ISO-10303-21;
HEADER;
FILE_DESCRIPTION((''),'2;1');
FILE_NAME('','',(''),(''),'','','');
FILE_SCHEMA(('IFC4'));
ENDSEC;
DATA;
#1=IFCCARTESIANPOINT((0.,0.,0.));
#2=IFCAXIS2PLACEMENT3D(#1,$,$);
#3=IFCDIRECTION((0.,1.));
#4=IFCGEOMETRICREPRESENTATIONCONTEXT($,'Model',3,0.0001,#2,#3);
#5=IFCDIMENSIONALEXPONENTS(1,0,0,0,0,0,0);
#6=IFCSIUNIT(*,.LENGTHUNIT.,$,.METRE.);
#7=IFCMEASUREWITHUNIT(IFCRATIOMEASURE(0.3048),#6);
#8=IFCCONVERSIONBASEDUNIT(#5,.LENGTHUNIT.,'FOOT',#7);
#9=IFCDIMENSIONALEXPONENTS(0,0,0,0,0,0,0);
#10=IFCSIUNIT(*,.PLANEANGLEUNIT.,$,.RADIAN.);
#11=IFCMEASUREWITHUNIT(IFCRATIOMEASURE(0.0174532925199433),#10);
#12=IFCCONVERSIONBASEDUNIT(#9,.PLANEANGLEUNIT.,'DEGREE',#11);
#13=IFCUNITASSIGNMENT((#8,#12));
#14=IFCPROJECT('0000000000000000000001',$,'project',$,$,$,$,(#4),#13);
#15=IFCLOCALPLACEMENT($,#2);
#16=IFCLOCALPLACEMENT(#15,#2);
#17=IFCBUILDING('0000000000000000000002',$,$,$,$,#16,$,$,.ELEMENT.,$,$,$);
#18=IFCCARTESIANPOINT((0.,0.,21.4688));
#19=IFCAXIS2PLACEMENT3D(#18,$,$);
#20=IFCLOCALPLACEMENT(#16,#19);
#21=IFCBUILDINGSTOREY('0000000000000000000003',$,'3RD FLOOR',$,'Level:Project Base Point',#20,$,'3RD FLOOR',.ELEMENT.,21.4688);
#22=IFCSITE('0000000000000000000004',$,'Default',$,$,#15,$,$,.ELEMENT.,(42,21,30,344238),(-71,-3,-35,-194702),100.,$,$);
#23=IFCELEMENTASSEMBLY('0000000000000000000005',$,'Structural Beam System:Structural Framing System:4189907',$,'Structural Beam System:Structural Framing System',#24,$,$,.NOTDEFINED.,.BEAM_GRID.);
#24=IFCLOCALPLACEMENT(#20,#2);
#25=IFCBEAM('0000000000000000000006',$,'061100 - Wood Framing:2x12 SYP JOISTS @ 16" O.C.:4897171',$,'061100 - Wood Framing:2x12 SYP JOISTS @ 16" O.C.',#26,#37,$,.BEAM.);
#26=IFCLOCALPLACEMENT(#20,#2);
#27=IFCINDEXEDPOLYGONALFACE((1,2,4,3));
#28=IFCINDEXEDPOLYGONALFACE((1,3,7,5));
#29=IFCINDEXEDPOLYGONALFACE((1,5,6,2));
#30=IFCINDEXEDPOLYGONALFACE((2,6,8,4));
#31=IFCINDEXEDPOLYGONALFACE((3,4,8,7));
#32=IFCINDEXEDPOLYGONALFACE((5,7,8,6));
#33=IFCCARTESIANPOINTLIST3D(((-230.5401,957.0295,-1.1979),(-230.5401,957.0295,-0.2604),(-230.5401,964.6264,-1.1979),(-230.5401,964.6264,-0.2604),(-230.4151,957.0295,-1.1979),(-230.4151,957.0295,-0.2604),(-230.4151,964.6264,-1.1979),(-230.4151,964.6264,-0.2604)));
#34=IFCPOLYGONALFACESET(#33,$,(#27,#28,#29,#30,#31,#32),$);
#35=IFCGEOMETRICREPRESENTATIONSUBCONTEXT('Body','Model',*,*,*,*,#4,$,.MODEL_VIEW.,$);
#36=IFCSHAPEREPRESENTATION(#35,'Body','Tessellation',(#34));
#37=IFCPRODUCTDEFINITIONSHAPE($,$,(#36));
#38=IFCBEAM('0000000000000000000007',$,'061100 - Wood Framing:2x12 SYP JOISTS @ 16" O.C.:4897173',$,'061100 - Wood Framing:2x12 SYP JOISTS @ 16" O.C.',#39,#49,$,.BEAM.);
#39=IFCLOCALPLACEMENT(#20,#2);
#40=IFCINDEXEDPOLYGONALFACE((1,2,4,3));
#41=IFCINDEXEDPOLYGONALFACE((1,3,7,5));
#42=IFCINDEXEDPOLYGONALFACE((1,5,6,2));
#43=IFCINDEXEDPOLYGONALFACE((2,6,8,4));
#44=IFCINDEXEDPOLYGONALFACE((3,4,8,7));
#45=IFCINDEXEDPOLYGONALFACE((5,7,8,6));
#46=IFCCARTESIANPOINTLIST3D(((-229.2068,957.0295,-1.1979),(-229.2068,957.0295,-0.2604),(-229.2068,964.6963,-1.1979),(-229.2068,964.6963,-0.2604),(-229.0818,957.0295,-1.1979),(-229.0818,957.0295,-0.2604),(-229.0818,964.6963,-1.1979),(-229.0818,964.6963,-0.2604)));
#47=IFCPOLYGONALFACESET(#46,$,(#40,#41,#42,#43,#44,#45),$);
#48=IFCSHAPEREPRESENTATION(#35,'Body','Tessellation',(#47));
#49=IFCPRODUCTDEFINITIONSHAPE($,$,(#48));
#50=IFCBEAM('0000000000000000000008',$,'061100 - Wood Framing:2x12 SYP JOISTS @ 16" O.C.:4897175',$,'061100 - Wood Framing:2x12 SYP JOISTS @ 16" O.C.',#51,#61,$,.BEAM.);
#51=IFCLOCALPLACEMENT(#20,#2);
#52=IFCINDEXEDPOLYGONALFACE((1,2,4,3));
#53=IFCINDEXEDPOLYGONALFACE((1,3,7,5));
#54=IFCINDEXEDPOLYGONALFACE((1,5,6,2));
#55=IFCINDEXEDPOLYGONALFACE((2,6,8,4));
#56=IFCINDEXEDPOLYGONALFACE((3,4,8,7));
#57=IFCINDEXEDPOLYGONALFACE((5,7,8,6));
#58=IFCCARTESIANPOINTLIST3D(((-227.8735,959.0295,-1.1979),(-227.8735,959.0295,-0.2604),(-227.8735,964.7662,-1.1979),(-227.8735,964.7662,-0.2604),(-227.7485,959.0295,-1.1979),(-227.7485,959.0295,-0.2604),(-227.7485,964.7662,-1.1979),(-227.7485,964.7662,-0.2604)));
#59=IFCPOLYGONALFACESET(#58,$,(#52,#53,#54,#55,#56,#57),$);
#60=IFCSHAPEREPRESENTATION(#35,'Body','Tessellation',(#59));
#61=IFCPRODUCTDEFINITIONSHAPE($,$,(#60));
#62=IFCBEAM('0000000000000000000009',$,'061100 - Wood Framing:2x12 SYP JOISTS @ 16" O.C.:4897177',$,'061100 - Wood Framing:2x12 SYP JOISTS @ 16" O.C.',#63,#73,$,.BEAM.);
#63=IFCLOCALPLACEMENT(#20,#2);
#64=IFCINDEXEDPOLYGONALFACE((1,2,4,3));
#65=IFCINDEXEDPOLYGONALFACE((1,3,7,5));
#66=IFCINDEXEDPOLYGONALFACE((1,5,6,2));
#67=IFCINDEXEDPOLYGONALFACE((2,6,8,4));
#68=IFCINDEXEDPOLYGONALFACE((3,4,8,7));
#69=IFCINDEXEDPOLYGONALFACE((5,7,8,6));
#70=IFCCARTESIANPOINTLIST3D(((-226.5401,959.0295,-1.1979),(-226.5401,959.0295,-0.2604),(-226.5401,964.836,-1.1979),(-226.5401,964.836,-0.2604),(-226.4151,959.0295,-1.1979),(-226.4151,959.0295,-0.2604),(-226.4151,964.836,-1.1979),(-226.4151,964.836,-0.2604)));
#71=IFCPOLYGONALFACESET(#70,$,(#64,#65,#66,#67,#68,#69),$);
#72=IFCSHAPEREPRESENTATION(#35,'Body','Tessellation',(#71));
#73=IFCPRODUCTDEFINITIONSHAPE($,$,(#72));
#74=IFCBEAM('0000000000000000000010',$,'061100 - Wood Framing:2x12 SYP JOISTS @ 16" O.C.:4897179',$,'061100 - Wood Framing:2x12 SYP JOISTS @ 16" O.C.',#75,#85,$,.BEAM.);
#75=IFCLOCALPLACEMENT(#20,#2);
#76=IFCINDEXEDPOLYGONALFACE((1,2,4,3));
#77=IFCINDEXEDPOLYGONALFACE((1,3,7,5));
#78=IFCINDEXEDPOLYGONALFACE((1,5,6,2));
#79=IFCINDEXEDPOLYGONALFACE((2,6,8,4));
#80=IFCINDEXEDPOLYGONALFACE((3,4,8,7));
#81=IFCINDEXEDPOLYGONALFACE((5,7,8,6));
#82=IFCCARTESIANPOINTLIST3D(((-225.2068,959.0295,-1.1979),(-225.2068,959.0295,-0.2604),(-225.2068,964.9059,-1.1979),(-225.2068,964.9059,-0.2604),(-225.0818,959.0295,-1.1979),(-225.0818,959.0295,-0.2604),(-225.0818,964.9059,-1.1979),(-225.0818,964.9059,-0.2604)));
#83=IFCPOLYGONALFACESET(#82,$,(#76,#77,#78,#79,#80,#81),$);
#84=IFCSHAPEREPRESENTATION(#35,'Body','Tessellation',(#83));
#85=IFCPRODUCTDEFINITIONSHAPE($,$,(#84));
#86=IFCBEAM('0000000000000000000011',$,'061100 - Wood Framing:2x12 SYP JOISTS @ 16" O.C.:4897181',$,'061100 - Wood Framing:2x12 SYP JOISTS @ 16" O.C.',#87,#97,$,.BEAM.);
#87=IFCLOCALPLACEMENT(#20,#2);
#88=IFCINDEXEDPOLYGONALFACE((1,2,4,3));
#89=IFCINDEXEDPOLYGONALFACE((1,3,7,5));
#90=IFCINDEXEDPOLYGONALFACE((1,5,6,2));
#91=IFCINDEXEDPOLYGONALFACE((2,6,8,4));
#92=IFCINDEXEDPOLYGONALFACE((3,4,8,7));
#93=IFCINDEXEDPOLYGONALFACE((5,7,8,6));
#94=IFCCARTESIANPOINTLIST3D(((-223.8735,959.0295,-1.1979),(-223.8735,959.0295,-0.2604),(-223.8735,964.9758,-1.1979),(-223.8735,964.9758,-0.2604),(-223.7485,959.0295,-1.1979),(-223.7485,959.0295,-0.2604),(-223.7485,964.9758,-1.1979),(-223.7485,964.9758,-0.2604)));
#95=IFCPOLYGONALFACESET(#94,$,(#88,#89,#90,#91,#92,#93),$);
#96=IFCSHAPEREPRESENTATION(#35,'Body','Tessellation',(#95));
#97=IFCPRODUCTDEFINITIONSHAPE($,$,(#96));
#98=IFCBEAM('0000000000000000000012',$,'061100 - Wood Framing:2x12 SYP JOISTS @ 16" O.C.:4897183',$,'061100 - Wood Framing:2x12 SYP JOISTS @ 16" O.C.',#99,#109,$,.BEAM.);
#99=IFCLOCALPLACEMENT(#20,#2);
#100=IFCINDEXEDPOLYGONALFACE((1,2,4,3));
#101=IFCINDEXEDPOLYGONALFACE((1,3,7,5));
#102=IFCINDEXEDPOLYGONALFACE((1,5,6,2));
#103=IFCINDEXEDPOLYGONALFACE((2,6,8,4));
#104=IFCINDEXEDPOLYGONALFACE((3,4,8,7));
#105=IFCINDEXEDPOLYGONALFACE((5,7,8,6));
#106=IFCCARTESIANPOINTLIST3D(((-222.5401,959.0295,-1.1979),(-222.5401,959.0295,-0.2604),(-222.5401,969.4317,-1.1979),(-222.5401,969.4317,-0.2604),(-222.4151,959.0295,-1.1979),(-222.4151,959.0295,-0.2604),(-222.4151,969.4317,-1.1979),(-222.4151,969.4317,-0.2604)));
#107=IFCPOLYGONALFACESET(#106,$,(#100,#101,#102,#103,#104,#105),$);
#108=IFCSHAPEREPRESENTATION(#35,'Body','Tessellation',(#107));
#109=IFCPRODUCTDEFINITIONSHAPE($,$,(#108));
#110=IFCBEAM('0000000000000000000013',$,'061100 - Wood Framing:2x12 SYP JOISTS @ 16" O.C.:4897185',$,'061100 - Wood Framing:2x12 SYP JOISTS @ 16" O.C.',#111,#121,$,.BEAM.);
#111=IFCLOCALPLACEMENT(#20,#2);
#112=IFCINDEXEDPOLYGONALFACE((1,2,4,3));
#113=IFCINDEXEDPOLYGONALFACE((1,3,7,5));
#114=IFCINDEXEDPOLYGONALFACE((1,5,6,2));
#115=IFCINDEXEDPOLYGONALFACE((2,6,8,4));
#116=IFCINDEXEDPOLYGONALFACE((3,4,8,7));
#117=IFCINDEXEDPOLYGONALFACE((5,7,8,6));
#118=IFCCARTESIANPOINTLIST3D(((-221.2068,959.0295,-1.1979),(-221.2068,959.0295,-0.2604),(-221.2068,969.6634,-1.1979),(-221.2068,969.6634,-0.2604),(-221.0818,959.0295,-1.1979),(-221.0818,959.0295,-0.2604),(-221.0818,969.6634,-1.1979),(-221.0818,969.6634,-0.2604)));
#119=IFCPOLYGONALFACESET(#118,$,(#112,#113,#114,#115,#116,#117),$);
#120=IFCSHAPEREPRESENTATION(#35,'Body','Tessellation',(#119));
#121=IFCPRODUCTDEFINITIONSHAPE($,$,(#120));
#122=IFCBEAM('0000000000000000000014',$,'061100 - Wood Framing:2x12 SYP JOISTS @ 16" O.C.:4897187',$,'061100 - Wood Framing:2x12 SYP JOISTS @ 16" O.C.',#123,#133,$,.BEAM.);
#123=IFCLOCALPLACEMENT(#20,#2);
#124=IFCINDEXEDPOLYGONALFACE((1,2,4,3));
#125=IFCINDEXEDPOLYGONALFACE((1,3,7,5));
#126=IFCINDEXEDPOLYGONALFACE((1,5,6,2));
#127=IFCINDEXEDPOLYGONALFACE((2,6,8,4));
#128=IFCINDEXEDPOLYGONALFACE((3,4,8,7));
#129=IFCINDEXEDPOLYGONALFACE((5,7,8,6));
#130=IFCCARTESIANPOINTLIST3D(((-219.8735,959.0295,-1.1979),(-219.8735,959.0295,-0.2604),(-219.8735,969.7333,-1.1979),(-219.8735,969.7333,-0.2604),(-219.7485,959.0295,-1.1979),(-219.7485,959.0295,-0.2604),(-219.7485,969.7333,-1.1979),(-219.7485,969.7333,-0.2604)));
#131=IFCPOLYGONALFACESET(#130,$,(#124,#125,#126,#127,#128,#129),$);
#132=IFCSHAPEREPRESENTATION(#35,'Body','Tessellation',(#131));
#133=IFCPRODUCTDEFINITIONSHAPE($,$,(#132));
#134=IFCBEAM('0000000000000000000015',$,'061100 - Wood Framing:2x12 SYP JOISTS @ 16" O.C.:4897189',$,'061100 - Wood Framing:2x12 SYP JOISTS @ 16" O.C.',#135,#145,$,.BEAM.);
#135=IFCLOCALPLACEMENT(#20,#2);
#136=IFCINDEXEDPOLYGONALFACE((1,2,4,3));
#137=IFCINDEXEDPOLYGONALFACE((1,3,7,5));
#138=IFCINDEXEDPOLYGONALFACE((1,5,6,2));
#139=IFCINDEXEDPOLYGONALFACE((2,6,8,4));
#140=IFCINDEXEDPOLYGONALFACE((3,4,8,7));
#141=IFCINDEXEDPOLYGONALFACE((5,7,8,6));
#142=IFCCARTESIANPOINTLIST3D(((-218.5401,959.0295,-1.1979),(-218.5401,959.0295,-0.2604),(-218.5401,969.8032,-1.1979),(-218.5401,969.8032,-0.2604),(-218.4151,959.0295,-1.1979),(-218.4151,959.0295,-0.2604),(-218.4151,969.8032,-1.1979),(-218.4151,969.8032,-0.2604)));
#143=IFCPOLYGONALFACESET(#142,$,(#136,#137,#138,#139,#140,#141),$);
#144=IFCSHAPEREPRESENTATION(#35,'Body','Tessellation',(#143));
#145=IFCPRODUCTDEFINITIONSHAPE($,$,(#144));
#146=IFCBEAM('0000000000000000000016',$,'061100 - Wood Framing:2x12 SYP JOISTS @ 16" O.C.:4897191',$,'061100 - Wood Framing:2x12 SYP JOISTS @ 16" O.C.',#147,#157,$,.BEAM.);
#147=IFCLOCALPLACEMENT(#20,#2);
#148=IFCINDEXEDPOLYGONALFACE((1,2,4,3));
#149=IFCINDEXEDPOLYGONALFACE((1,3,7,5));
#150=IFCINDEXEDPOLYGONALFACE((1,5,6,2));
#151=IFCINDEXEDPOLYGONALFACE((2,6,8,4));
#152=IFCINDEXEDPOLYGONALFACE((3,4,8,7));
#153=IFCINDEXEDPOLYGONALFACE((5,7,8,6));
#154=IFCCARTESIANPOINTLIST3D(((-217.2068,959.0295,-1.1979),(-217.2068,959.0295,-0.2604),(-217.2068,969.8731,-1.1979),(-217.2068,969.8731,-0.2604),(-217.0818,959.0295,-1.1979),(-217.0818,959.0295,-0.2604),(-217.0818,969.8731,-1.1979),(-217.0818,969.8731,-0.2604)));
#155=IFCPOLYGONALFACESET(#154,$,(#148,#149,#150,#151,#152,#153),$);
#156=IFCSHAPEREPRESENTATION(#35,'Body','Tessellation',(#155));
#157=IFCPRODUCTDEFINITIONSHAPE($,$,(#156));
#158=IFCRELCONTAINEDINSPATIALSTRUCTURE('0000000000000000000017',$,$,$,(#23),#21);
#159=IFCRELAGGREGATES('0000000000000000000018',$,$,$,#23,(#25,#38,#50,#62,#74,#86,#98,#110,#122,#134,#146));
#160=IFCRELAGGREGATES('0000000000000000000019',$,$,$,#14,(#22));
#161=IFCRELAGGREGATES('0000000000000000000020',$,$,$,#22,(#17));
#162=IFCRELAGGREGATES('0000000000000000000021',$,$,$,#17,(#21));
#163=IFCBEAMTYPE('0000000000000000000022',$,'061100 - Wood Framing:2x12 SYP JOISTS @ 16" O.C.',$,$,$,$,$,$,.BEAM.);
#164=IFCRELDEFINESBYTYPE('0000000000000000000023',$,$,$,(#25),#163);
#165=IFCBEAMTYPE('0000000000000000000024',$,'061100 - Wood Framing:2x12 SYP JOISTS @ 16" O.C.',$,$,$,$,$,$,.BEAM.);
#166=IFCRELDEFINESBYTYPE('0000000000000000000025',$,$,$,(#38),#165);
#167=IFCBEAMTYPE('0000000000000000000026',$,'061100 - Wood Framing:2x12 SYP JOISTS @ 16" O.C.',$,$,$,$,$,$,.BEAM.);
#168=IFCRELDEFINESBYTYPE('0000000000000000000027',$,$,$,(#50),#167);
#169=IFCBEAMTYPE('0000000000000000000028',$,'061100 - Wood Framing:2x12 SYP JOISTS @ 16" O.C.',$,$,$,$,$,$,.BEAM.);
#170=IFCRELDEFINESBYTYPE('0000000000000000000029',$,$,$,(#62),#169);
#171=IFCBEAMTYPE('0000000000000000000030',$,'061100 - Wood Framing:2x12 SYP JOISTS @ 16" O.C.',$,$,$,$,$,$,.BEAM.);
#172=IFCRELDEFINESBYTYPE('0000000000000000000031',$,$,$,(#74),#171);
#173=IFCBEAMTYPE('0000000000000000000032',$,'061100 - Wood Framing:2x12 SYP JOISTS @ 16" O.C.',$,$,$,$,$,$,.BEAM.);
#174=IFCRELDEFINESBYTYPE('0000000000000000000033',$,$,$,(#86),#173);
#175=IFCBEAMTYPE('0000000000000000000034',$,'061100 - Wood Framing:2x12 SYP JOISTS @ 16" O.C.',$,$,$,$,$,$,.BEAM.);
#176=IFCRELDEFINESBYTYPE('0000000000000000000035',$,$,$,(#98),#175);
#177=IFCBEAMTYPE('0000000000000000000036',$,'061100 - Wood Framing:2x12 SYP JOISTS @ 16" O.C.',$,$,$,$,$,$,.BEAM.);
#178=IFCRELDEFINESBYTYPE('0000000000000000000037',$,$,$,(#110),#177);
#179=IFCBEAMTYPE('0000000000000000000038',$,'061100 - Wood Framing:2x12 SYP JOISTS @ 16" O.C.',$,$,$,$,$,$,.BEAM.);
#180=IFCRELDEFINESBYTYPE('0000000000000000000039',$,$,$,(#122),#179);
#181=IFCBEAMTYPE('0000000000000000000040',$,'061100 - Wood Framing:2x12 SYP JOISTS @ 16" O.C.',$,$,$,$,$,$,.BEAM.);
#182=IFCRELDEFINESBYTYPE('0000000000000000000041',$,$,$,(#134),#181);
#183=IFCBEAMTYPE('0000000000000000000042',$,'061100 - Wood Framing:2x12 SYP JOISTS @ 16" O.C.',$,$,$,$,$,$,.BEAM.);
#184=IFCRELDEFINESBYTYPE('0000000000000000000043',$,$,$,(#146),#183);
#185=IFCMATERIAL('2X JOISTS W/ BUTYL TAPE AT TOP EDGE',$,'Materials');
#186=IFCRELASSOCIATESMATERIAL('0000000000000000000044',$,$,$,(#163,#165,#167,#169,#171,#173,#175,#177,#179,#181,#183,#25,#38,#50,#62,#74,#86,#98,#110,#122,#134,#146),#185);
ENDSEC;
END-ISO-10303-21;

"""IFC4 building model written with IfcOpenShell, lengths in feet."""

from ifc_helpers import new_model, entity, si_unit, converted_unit, direction, frame, origin, origin_2d_with_axis, place, context, subcontext, project, spatial, rectangle, extrude, source, transform, mapped, material, material_profile, profile_set, profile_usage, type_object, type_shapes, element, aggregate, save


model = new_model("IFC4")

# Units and contexts
model_context = context("Model", 3, precision=0.0001, world=origin(), true_north=direction((0.0, 1.0)))
body_context = subcontext(model_context, "Body", "Model", "MODEL_VIEW")
ifc_project = project(units=[converted_unit("LENGTHUNIT", "FOOT", entity("IfcRatioMeasure", 0.3048), si_unit("LENGTHUNIT", "METRE"), dimensions=[1, 0, 0, 0, 0, 0, 0]), converted_unit("PLANEANGLEUNIT", "DEGREE", entity("IfcRatioMeasure", 0.0174532925199433), si_unit("PLANEANGLEUNIT", "RADIAN"), dimensions=[0, 0, 0, 0, 0, 0, 0])], contexts=[model_context])

# Site, building, storey
site_placement = place(None, origin())
site = spatial("IfcSite", under=ifc_project, at=site_placement, Name="Default", CompositionType="ELEMENT", RefLatitude=(42, 21, 30, 344238), RefLongitude=(-71, -3, -35, -194702), RefElevation=100.0)
building_placement = place(site_placement, origin())
building = spatial("IfcBuilding", under=site, at=building_placement, CompositionType="ELEMENT")
storey_placement = place(building_placement, frame((0.0, 0.0, 21.4688)))
storey = spatial("IfcBuildingStorey", under=building, at=storey_placement, Name="3RD FLOOR", ObjectType="Level:Project Base Point", LongName="3RD FLOOR", CompositionType="ELEMENT", Elevation=21.4688)

# Element assembly, beams
assembly_1_placement = place(storey_placement, origin())
assembly_1 = element("IfcElementAssembly", 1, at=assembly_1_placement, inside=storey, Name="Structural Beam System:Structural Framing System:4189907", ObjectType="Structural Beam System:Structural Framing System", AssemblyPlace="NOTDEFINED", PredefinedType="BEAM_GRID")
ifc_material_1 = material(Name="2X JOISTS W/ BUTYL TAPE AT TOP EDGE", Category="Materials")
ifc_material_profile_1 = material_profile(ifc_material_1, rectangle(XDim=0.9375, YDim=0.125, at=origin_2d_with_axis()), Name="2x12 SYP JOISTS @ 16\" O.C.")
ifc_profile_set_1 = profile_set([ifc_material_profile_1], Name="2x12 SYP JOISTS @ 16\" O.C.")
ifc_profile_usage_1 = profile_usage(ifc_profile_set_1, cardinal=8)
beam_type_1 = type_object("IfcBeamType", Name="061100 - Wood Framing:2x12 SYP JOISTS @ 16\" O.C.", PredefinedType="BEAM", material=ifc_profile_set_1)
shared_shape_1 = source(origin(), body_context, "Body", "SweptSolid", [
    extrude(rectangle(XDim=0.9375, YDim=0.125, at=origin_2d_with_axis()), frame((-3.7984, 0.0, 0.0), z_axis=(1.0, 0.0, 0.0), x_axis=(0.0, 0.0, -1.0)), (0.0, 0.0, 1.0), 7.5969),
])
type_shapes(beam_type_1, [shared_shape_1])
beam_1_placement = place(assembly_1_placement, frame((-230.4776, 960.828, -0.7292), z_axis=(0.0, 0.0, 1.0), x_axis=(0.0, 1.0, 0.0)))
beam_1 = element("IfcBeam", 2, at=beam_1_placement, type_object=beam_type_1, material=ifc_profile_usage_1, Name="061100 - Wood Framing:2x12 SYP JOISTS @ 16\" O.C.:4897171", ObjectType="061100 - Wood Framing:2x12 SYP JOISTS @ 16\" O.C.", PredefinedType="BEAM", context=body_context, shape_type="MappedRepresentation", body=[
    mapped(shared_shape_1, transform((0.0, 0.0, 0.0), scale=1.0)),
])
ifc_profile_usage_2 = profile_usage(ifc_profile_set_1, cardinal=8)
beam_type_2 = type_object("IfcBeamType", Name="061100 - Wood Framing:2x12 SYP JOISTS @ 16\" O.C.", PredefinedType="BEAM", material=ifc_profile_set_1)
shared_shape_2 = source(origin(), body_context, "Body", "SweptSolid", [
    extrude(rectangle(XDim=0.9375, YDim=0.125, at=origin_2d_with_axis()), frame((-3.8334, 0.0, 0.0), z_axis=(1.0, 0.0, 0.0), x_axis=(0.0, 0.0, -1.0)), (0.0, 0.0, 1.0), 7.6668),
])
type_shapes(beam_type_2, [shared_shape_2])
beam_2_placement = place(assembly_1_placement, frame((-229.1443, 960.8629, -0.7292), z_axis=(0.0, 0.0, 1.0), x_axis=(0.0, 1.0, 0.0)))
beam_2 = element("IfcBeam", 3, at=beam_2_placement, type_object=beam_type_2, material=ifc_profile_usage_2, Name="061100 - Wood Framing:2x12 SYP JOISTS @ 16\" O.C.:4897173", ObjectType="061100 - Wood Framing:2x12 SYP JOISTS @ 16\" O.C.", PredefinedType="BEAM", context=body_context, shape_type="MappedRepresentation", body=[
    mapped(shared_shape_2, transform((0.0, 0.0, 0.0), scale=1.0)),
])
ifc_profile_usage_3 = profile_usage(ifc_profile_set_1, cardinal=8)
beam_type_3 = type_object("IfcBeamType", Name="061100 - Wood Framing:2x12 SYP JOISTS @ 16\" O.C.", PredefinedType="BEAM", material=ifc_profile_set_1)
shared_shape_3 = source(origin(), body_context, "Body", "SweptSolid", [
    extrude(rectangle(XDim=0.9375, YDim=0.125, at=origin_2d_with_axis()), frame((-2.8683, 0.0, 0.0), z_axis=(1.0, 0.0, 0.0), x_axis=(0.0, 0.0, -1.0)), (0.0, 0.0, 1.0), 5.7366),
])
type_shapes(beam_type_3, [shared_shape_3])
beam_3_placement = place(assembly_1_placement, frame((-227.811, 961.8978, -0.7292), z_axis=(0.0, 0.0, 1.0), x_axis=(0.0, 1.0, 0.0)))
beam_3 = element("IfcBeam", 4, at=beam_3_placement, type_object=beam_type_3, material=ifc_profile_usage_3, Name="061100 - Wood Framing:2x12 SYP JOISTS @ 16\" O.C.:4897175", ObjectType="061100 - Wood Framing:2x12 SYP JOISTS @ 16\" O.C.", PredefinedType="BEAM", context=body_context, shape_type="MappedRepresentation", body=[
    mapped(shared_shape_3, transform((0.0, 0.0, 0.0), scale=1.0)),
])
ifc_profile_usage_4 = profile_usage(ifc_profile_set_1, cardinal=8)
beam_type_4 = type_object("IfcBeamType", Name="061100 - Wood Framing:2x12 SYP JOISTS @ 16\" O.C.", PredefinedType="BEAM", material=ifc_profile_set_1)
shared_shape_4 = source(origin(), body_context, "Body", "SweptSolid", [
    extrude(rectangle(XDim=0.9375, YDim=0.125, at=origin_2d_with_axis()), frame((-2.9033, 0.0, 0.0), z_axis=(1.0, 0.0, 0.0), x_axis=(0.0, 0.0, -1.0)), (0.0, 0.0, 1.0), 5.8065),
])
type_shapes(beam_type_4, [shared_shape_4])
beam_4_placement = place(assembly_1_placement, frame((-226.4776, 961.9328, -0.7292), z_axis=(0.0, 0.0, 1.0), x_axis=(0.0, 1.0, 0.0)))
beam_4 = element("IfcBeam", 5, at=beam_4_placement, type_object=beam_type_4, material=ifc_profile_usage_4, Name="061100 - Wood Framing:2x12 SYP JOISTS @ 16\" O.C.:4897177", ObjectType="061100 - Wood Framing:2x12 SYP JOISTS @ 16\" O.C.", PredefinedType="BEAM", context=body_context, shape_type="MappedRepresentation", body=[
    mapped(shared_shape_4, transform((0.0, 0.0, 0.0), scale=1.0)),
])
ifc_profile_usage_5 = profile_usage(ifc_profile_set_1, cardinal=8)
beam_type_5 = type_object("IfcBeamType", Name="061100 - Wood Framing:2x12 SYP JOISTS @ 16\" O.C.", PredefinedType="BEAM", material=ifc_profile_set_1)
shared_shape_5 = source(origin(), body_context, "Body", "SweptSolid", [
    extrude(rectangle(XDim=0.9375, YDim=0.125, at=origin_2d_with_axis()), frame((-2.9382, 0.0, 0.0), z_axis=(1.0, 0.0, 0.0), x_axis=(0.0, 0.0, -1.0)), (0.0, 0.0, 1.0), 5.8764),
])
type_shapes(beam_type_5, [shared_shape_5])
beam_5_placement = place(assembly_1_placement, frame((-225.1443, 961.9677, -0.7292), z_axis=(0.0, 0.0, 1.0), x_axis=(0.0, 1.0, 0.0)))
beam_5 = element("IfcBeam", 6, at=beam_5_placement, type_object=beam_type_5, material=ifc_profile_usage_5, Name="061100 - Wood Framing:2x12 SYP JOISTS @ 16\" O.C.:4897179", ObjectType="061100 - Wood Framing:2x12 SYP JOISTS @ 16\" O.C.", PredefinedType="BEAM", context=body_context, shape_type="MappedRepresentation", body=[
    mapped(shared_shape_5, transform((0.0, 0.0, 0.0), scale=1.0)),
])
ifc_profile_usage_6 = profile_usage(ifc_profile_set_1, cardinal=8)
beam_type_6 = type_object("IfcBeamType", Name="061100 - Wood Framing:2x12 SYP JOISTS @ 16\" O.C.", PredefinedType="BEAM", material=ifc_profile_set_1)
shared_shape_6 = source(origin(), body_context, "Body", "SweptSolid", [
    extrude(rectangle(XDim=0.9375, YDim=0.125, at=origin_2d_with_axis()), frame((-2.9731, 0.0, 0.0), z_axis=(1.0, 0.0, 0.0), x_axis=(0.0, 0.0, -1.0)), (0.0, 0.0, 1.0), 5.9463),
])
type_shapes(beam_type_6, [shared_shape_6])
beam_6_placement = place(assembly_1_placement, frame((-223.811, 962.0027, -0.7292), z_axis=(0.0, 0.0, 1.0), x_axis=(0.0, 1.0, 0.0)))
beam_6 = element("IfcBeam", 7, at=beam_6_placement, type_object=beam_type_6, material=ifc_profile_usage_6, Name="061100 - Wood Framing:2x12 SYP JOISTS @ 16\" O.C.:4897181", ObjectType="061100 - Wood Framing:2x12 SYP JOISTS @ 16\" O.C.", PredefinedType="BEAM", context=body_context, shape_type="MappedRepresentation", body=[
    mapped(shared_shape_6, transform((0.0, 0.0, 0.0), scale=1.0)),
])
ifc_profile_usage_7 = profile_usage(ifc_profile_set_1, cardinal=8)
beam_type_7 = type_object("IfcBeamType", Name="061100 - Wood Framing:2x12 SYP JOISTS @ 16\" O.C.", PredefinedType="BEAM", material=ifc_profile_set_1)
shared_shape_7 = source(origin(), body_context, "Body", "SweptSolid", [
    extrude(rectangle(XDim=0.9375, YDim=0.125, at=origin_2d_with_axis()), frame((-5.3117, 0.0, 0.0), z_axis=(1.0, 0.0, 0.0), x_axis=(0.0, 0.0, -1.0)), (0.0, 0.0, 1.0), 10.4022),
])
type_shapes(beam_type_7, [shared_shape_7])
beam_7_placement = place(assembly_1_placement, frame((-222.4776, 964.3412, -0.7292), z_axis=(0.0, 0.0, 1.0), x_axis=(0.0, 1.0, 0.0)))
beam_7 = element("IfcBeam", 8, at=beam_7_placement, type_object=beam_type_7, material=ifc_profile_usage_7, Name="061100 - Wood Framing:2x12 SYP JOISTS @ 16\" O.C.:4897183", ObjectType="061100 - Wood Framing:2x12 SYP JOISTS @ 16\" O.C.", PredefinedType="BEAM", context=body_context, shape_type="MappedRepresentation", body=[
    mapped(shared_shape_7, transform((0.0, 0.0, 0.0), scale=1.0)),
])
ifc_profile_usage_8 = profile_usage(ifc_profile_set_1, cardinal=8)
beam_type_8 = type_object("IfcBeamType", Name="061100 - Wood Framing:2x12 SYP JOISTS @ 16\" O.C.", PredefinedType="BEAM", material=ifc_profile_set_1)
shared_shape_8 = source(origin(), body_context, "Body", "SweptSolid", [
    extrude(rectangle(XDim=0.9375, YDim=0.125, at=origin_2d_with_axis()), frame((-5.317, 0.0, 0.0), z_axis=(1.0, 0.0, 0.0), x_axis=(0.0, 0.0, -1.0)), (0.0, 0.0, 1.0), 10.6339),
])
type_shapes(beam_type_8, [shared_shape_8])
beam_8_placement = place(assembly_1_placement, frame((-221.1443, 964.3465, -0.7292), z_axis=(0.0, 0.0, 1.0), x_axis=(0.0, 1.0, 0.0)))
beam_8 = element("IfcBeam", 9, at=beam_8_placement, type_object=beam_type_8, material=ifc_profile_usage_8, Name="061100 - Wood Framing:2x12 SYP JOISTS @ 16\" O.C.:4897185", ObjectType="061100 - Wood Framing:2x12 SYP JOISTS @ 16\" O.C.", PredefinedType="BEAM", context=body_context, shape_type="MappedRepresentation", body=[
    mapped(shared_shape_8, transform((0.0, 0.0, 0.0), scale=1.0)),
])
ifc_profile_usage_9 = profile_usage(ifc_profile_set_1, cardinal=8)
beam_type_9 = type_object("IfcBeamType", Name="061100 - Wood Framing:2x12 SYP JOISTS @ 16\" O.C.", PredefinedType="BEAM", material=ifc_profile_set_1)
shared_shape_9 = source(origin(), body_context, "Body", "SweptSolid", [
    extrude(rectangle(XDim=0.9375, YDim=0.125, at=origin_2d_with_axis()), frame((-5.3519, 0.0, 0.0), z_axis=(1.0, 0.0, 0.0), x_axis=(0.0, 0.0, -1.0)), (0.0, 0.0, 1.0), 10.7038),
])
type_shapes(beam_type_9, [shared_shape_9])
beam_9_placement = place(assembly_1_placement, frame((-219.811, 964.3814, -0.7292), z_axis=(0.0, 0.0, 1.0), x_axis=(0.0, 1.0, 0.0)))
beam_9 = element("IfcBeam", 10, at=beam_9_placement, type_object=beam_type_9, material=ifc_profile_usage_9, Name="061100 - Wood Framing:2x12 SYP JOISTS @ 16\" O.C.:4897187", ObjectType="061100 - Wood Framing:2x12 SYP JOISTS @ 16\" O.C.", PredefinedType="BEAM", context=body_context, shape_type="MappedRepresentation", body=[
    mapped(shared_shape_9, transform((0.0, 0.0, 0.0), scale=1.0)),
])
ifc_profile_usage_10 = profile_usage(ifc_profile_set_1, cardinal=8)
beam_type_10 = type_object("IfcBeamType", Name="061100 - Wood Framing:2x12 SYP JOISTS @ 16\" O.C.", PredefinedType="BEAM", material=ifc_profile_set_1)
shared_shape_10 = source(origin(), body_context, "Body", "SweptSolid", [
    extrude(rectangle(XDim=0.9375, YDim=0.125, at=origin_2d_with_axis()), frame((-5.3868, 0.0, 0.0), z_axis=(1.0, 0.0, 0.0), x_axis=(0.0, 0.0, -1.0)), (0.0, 0.0, 1.0), 10.7737),
])
type_shapes(beam_type_10, [shared_shape_10])
beam_10_placement = place(assembly_1_placement, frame((-218.4776, 964.4164, -0.7292), z_axis=(0.0, 0.0, 1.0), x_axis=(0.0, 1.0, 0.0)))
beam_10 = element("IfcBeam", 11, at=beam_10_placement, type_object=beam_type_10, material=ifc_profile_usage_10, Name="061100 - Wood Framing:2x12 SYP JOISTS @ 16\" O.C.:4897189", ObjectType="061100 - Wood Framing:2x12 SYP JOISTS @ 16\" O.C.", PredefinedType="BEAM", context=body_context, shape_type="MappedRepresentation", body=[
    mapped(shared_shape_10, transform((0.0, 0.0, 0.0), scale=1.0)),
])
ifc_profile_usage_11 = profile_usage(ifc_profile_set_1, cardinal=8)
beam_type_11 = type_object("IfcBeamType", Name="061100 - Wood Framing:2x12 SYP JOISTS @ 16\" O.C.", PredefinedType="BEAM", material=ifc_profile_set_1)
shared_shape_11 = source(origin(), body_context, "Body", "SweptSolid", [
    extrude(rectangle(XDim=0.9375, YDim=0.125, at=origin_2d_with_axis()), frame((-5.4218, 0.0, 0.0), z_axis=(1.0, 0.0, 0.0), x_axis=(0.0, 0.0, -1.0)), (0.0, 0.0, 1.0), 10.8436),
])
type_shapes(beam_type_11, [shared_shape_11])
beam_11_placement = place(assembly_1_placement, frame((-217.1443, 964.4513, -0.7292), z_axis=(0.0, 0.0, 1.0), x_axis=(0.0, 1.0, 0.0)))
beam_11 = element("IfcBeam", 12, at=beam_11_placement, type_object=beam_type_11, material=ifc_profile_usage_11, Name="061100 - Wood Framing:2x12 SYP JOISTS @ 16\" O.C.:4897191", ObjectType="061100 - Wood Framing:2x12 SYP JOISTS @ 16\" O.C.", PredefinedType="BEAM", context=body_context, shape_type="MappedRepresentation", body=[
    mapped(shared_shape_11, transform((0.0, 0.0, 0.0), scale=1.0)),
])
aggregate(assembly_1, [beam_1, beam_2, beam_3, beam_4, beam_5, beam_6, beam_7, beam_8, beam_9, beam_10, beam_11])

save(model, "model.ifc")
